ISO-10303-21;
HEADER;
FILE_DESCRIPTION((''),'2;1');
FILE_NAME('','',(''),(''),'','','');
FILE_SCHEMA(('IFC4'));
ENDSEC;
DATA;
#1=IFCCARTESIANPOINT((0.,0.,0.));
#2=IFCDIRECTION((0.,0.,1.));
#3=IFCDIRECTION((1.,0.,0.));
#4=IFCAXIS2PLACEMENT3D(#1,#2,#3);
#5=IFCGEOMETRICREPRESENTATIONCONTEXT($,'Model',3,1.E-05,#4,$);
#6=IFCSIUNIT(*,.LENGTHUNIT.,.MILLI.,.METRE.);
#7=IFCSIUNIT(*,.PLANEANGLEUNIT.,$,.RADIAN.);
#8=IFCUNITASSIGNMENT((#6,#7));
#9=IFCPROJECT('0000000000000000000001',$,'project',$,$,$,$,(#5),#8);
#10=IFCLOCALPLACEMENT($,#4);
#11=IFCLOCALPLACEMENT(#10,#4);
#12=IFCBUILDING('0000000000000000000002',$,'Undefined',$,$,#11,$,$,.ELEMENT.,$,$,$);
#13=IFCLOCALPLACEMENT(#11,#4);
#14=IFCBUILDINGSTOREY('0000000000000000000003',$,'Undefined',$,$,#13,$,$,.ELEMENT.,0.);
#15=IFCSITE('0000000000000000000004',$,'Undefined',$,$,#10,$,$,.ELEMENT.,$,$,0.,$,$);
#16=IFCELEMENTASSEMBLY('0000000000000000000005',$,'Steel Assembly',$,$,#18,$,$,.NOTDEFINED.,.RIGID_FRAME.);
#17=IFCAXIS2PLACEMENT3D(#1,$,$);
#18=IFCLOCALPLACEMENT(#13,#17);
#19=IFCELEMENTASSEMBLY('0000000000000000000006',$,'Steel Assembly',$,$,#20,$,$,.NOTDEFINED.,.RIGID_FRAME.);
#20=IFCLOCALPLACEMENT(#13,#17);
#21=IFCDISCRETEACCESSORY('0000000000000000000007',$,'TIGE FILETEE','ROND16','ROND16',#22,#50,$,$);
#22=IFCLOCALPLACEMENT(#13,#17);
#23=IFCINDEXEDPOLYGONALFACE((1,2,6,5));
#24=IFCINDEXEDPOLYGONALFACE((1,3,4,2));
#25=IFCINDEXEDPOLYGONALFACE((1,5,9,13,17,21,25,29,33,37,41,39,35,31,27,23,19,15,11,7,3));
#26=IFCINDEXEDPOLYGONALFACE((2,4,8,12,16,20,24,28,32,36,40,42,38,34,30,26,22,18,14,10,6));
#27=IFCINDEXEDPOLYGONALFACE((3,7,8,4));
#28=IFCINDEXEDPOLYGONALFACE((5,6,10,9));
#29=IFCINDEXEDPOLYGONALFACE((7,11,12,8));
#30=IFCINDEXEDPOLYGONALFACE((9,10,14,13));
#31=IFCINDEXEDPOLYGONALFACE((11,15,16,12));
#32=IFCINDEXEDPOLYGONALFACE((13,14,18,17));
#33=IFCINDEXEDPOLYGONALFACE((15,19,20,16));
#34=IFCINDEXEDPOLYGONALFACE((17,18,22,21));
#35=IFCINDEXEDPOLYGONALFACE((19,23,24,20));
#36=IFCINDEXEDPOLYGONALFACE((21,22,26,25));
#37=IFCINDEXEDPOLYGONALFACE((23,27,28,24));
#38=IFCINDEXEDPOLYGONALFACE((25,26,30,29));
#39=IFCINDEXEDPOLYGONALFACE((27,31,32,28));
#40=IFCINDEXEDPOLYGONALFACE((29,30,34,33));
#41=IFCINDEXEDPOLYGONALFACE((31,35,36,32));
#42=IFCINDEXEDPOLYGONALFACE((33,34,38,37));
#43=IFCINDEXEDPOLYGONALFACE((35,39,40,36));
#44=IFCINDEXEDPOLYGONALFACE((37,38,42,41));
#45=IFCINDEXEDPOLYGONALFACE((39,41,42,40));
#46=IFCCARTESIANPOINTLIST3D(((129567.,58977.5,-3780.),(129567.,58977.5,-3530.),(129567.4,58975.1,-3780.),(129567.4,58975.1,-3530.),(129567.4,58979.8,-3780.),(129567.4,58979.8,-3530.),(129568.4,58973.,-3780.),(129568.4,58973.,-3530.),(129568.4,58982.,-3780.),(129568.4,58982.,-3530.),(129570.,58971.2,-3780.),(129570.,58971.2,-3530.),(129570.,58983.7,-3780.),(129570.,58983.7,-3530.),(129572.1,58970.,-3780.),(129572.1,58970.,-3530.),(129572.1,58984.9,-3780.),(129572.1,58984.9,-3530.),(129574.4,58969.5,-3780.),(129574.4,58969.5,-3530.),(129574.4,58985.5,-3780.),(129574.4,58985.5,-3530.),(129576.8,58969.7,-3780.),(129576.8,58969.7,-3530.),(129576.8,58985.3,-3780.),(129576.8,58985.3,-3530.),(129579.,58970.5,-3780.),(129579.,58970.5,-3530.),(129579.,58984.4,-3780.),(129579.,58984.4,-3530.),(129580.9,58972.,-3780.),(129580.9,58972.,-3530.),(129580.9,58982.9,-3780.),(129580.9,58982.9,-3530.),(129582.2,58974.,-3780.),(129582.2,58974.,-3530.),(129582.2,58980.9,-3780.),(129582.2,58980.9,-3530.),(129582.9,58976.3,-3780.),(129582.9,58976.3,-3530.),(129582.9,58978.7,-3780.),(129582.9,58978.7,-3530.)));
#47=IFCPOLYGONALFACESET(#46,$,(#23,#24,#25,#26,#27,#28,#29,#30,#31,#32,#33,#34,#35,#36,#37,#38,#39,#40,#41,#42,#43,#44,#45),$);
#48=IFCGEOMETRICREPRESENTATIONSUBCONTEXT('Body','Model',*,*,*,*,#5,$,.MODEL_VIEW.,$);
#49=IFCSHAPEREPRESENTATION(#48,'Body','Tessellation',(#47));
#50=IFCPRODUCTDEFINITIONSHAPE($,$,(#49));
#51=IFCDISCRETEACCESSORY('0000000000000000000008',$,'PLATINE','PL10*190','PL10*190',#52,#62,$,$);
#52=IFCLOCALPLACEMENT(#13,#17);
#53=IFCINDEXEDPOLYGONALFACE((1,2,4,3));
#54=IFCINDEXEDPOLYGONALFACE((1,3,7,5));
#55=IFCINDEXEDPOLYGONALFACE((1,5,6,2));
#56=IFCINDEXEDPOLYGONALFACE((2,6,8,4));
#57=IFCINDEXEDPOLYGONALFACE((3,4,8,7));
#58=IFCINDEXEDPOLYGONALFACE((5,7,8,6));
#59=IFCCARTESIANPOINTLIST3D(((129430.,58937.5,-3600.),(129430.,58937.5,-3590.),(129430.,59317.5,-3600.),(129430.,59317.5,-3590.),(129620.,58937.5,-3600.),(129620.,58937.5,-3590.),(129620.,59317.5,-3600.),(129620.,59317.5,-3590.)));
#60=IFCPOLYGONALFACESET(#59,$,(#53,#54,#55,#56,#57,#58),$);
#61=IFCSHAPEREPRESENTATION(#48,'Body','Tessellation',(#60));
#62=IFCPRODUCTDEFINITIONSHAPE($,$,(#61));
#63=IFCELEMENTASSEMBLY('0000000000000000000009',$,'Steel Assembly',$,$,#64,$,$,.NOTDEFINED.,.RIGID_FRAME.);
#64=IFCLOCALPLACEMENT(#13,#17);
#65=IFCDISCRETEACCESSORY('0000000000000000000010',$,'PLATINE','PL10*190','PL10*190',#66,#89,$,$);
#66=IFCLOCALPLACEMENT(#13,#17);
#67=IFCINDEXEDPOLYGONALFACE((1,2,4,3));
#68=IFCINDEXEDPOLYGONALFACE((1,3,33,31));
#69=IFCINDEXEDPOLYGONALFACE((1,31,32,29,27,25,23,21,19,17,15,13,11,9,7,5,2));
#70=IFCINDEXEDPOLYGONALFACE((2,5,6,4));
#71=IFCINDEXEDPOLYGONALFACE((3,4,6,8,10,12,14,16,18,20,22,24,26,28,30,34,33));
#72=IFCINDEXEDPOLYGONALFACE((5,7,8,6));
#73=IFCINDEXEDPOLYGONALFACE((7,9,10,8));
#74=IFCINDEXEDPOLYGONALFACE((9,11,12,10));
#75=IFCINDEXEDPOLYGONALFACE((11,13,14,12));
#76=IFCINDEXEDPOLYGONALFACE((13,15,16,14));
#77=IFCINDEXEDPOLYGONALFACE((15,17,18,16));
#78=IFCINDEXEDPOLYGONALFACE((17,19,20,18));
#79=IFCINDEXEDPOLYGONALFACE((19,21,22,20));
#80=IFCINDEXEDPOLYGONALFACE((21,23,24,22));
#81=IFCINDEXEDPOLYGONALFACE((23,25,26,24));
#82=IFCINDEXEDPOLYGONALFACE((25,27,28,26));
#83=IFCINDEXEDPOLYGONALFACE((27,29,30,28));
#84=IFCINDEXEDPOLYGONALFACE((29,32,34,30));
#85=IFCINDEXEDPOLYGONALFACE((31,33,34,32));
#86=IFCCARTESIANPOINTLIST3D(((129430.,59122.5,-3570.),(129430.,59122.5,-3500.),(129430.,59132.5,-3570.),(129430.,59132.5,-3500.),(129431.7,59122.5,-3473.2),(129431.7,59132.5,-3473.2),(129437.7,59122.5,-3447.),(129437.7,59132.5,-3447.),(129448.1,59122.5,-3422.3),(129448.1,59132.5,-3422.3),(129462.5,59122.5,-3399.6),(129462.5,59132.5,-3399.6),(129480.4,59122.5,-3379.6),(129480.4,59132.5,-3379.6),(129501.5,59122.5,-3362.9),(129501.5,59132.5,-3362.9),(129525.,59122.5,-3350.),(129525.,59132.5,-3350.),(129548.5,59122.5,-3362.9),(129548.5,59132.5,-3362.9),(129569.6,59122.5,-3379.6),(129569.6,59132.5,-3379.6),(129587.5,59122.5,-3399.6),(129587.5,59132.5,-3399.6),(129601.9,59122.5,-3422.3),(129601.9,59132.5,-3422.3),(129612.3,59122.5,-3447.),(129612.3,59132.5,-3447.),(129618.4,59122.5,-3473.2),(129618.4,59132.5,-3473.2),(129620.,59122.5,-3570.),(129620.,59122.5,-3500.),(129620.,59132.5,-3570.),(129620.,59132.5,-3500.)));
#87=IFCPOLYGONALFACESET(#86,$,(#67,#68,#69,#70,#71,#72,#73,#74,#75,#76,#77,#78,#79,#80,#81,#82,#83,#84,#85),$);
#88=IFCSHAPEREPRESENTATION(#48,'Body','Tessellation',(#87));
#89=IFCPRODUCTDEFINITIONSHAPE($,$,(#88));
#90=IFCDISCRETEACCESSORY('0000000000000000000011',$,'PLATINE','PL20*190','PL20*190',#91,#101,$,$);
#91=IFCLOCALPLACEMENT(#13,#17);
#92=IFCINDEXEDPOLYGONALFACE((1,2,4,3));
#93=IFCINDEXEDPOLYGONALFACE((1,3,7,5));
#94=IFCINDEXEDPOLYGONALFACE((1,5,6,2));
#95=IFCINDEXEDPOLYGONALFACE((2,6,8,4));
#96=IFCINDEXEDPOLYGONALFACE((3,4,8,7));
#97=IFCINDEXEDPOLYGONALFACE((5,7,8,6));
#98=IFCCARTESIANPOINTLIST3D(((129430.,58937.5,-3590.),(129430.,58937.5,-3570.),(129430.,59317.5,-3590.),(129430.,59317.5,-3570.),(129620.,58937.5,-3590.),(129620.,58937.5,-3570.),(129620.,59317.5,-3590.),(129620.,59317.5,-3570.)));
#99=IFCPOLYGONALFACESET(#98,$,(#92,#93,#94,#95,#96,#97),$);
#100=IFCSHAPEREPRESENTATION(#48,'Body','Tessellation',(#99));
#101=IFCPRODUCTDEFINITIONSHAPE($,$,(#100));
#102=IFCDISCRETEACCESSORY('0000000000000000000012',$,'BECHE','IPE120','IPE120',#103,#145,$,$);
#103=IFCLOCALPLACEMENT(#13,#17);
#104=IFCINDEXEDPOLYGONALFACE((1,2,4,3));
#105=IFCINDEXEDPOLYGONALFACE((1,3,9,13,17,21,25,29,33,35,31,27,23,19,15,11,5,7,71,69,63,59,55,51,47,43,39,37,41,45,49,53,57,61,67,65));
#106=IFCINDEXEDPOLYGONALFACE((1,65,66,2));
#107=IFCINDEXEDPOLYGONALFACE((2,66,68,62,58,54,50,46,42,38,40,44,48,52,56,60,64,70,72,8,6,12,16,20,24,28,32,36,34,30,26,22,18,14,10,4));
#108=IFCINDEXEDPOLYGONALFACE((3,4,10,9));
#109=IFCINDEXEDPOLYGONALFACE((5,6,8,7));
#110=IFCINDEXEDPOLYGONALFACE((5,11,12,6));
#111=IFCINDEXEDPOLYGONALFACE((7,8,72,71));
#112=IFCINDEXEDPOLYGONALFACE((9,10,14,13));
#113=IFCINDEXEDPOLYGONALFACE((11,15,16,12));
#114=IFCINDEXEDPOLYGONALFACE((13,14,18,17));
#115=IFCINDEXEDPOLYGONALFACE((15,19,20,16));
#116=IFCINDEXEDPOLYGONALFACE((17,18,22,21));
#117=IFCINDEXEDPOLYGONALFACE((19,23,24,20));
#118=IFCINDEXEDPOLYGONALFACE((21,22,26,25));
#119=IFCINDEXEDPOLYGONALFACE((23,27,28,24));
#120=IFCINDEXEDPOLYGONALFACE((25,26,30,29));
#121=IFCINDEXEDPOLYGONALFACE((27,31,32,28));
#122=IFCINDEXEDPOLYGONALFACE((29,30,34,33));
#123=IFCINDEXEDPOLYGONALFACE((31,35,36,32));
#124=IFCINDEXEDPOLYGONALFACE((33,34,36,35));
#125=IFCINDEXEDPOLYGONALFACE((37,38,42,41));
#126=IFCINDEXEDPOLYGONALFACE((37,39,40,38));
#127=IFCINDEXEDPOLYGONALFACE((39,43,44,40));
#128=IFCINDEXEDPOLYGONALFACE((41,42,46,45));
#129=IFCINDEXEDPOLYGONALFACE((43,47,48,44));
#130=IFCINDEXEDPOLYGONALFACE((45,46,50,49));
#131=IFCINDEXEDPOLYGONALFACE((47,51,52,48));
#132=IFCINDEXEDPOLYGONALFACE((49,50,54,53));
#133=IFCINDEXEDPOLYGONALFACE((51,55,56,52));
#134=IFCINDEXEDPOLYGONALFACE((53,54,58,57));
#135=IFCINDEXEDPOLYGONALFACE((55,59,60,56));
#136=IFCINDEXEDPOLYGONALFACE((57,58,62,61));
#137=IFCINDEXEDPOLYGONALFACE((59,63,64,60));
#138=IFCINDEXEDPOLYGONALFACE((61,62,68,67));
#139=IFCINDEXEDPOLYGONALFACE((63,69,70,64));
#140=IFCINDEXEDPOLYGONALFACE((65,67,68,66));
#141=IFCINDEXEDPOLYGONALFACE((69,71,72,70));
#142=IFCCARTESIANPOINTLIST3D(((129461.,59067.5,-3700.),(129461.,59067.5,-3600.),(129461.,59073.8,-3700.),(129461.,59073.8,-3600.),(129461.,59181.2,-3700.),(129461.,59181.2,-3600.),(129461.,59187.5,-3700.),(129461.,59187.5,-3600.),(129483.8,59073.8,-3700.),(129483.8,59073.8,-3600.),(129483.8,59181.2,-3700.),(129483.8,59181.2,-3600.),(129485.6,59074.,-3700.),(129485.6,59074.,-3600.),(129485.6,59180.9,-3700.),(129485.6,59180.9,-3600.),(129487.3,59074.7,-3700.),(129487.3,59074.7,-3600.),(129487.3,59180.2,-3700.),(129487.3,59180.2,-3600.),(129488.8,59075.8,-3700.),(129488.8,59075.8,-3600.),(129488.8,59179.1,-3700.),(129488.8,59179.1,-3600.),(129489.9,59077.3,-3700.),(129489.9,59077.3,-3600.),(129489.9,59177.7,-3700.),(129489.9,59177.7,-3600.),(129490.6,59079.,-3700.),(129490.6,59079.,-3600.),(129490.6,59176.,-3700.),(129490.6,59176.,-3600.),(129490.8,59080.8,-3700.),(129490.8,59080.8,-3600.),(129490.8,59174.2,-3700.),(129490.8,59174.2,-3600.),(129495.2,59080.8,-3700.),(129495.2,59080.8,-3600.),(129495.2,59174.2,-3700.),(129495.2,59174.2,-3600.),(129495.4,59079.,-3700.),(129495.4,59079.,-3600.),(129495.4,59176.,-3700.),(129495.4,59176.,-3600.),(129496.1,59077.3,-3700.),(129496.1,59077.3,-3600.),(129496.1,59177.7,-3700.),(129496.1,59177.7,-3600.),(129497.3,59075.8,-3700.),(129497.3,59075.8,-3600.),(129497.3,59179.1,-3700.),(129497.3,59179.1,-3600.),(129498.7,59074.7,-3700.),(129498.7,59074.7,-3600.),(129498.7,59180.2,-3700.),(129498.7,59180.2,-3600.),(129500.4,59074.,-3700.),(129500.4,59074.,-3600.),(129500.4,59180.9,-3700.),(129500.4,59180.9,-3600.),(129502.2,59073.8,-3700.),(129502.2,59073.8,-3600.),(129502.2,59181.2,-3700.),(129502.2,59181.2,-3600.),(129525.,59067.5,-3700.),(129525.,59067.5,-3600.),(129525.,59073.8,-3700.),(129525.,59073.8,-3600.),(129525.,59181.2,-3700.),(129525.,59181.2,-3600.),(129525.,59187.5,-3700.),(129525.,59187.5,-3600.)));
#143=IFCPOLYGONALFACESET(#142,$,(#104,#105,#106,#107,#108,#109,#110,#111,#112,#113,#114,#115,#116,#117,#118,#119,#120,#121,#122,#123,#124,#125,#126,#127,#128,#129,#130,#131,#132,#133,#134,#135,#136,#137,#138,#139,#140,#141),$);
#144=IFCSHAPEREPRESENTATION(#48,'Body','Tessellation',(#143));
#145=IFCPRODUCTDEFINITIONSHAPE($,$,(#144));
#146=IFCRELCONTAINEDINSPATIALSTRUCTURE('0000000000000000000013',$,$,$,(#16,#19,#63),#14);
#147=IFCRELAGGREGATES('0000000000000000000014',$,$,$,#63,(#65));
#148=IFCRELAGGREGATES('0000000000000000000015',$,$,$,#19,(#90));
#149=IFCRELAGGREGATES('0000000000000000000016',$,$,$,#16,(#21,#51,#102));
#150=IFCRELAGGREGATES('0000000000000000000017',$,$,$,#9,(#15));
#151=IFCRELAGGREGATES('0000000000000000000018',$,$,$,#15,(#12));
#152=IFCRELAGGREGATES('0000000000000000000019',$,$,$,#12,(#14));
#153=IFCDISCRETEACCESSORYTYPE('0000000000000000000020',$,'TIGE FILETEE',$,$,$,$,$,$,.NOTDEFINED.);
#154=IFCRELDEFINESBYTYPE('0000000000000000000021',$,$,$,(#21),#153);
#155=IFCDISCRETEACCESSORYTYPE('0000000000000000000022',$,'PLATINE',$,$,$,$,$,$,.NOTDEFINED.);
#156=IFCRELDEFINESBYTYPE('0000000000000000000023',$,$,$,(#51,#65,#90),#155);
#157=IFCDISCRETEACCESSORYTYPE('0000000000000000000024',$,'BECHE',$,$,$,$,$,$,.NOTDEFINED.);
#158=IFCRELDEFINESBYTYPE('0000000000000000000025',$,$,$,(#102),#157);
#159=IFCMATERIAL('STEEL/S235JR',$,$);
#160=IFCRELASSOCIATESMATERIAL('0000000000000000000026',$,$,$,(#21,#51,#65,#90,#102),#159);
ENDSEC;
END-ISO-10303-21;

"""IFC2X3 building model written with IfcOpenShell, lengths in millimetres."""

from ifc_helpers import new_model, si_unit, frame, frame_2d, origin_with_axes, origin_2d_with_axis, place, context, subcontext, project, spatial, polyline, circle_curve, parameter, trimmed, segment, composite_curve, circle, i_section, outline, extrude, boolean, material, type_object, element, aggregate, save


model = new_model("IFC2X3")

# Units and contexts
model_context = context("Model", 3, precision=1e-05, world=origin_with_axes())
body_context = subcontext(model_context, "Body", "Model", "MODEL_VIEW")
ifc_project = project(units=[si_unit("LENGTHUNIT", "METRE", prefix="MILLI"), si_unit("PLANEANGLEUNIT", "RADIAN")], contexts=[model_context])

# Site, building, storey
site_placement = place(None, origin_with_axes())
site = spatial("IfcSite", under=ifc_project, at=site_placement, Name="Undefined", CompositionType="ELEMENT", RefElevation=0.0)
building_placement = place(site_placement, origin_with_axes())
building = spatial("IfcBuilding", under=site, at=building_placement, Name="Undefined", CompositionType="ELEMENT")
storey_placement = place(building_placement, origin_with_axes())
storey = spatial("IfcBuildingStorey", under=building, at=storey_placement, Name="Undefined", CompositionType="ELEMENT", Elevation=0.0)

# Shared definitions
ifc_material_1 = material(Name="STEEL/S235JR")

# Element assembly
assembly_1_placement = place(storey_placement, origin_with_axes())
assembly_1 = element("IfcElementAssembly", 1, at=assembly_1_placement, inside=storey, Name="Steel Assembly", AssemblyPlace="NOTDEFINED", PredefinedType="RIGID_FRAME")

# Element assembly
assembly_2_placement = place(storey_placement, origin_with_axes())
assembly_2 = element("IfcElementAssembly", 2, at=assembly_2_placement, inside=storey, Name="Steel Assembly", AssemblyPlace="NOTDEFINED", PredefinedType="RIGID_FRAME")

# Discrete accessories
discrete_accessory_type_1 = type_object("IfcDiscreteAccessoryType", Name="TIGE FILETEE")
discrete_accessory_1_placement = place(assembly_1_placement, frame((129575.0, 58977.5, -3530.0), z_axis=(0.0, -1.0, 0.0), x_axis=(0.0, 0.0, -1.0)))
discrete_accessory_1 = element("IfcDiscreteAccessory", 3, at=discrete_accessory_1_placement, type_object=discrete_accessory_type_1, material=ifc_material_1, Name="TIGE FILETEE", Description="ROND16", ObjectType="ROND16", context=body_context, shape_type="SweptSolid", body=[
    extrude(circle(Radius=8.0, at=origin_2d_with_axis()), frame((250.0, 0.0, 0.0), z_axis=(-1.0, 0.0, 0.0), x_axis=(0.0, -1.0, 0.0)), (0.0, 0.0, 1.0), 250.0),
])
discrete_accessory_type_2 = type_object("IfcDiscreteAccessoryType", Name="PLATINE")
discrete_accessory_2_placement = place(assembly_1_placement, frame((129525.0, 58937.5, -3595.0), z_axis=(0.0, -0.000005, -1.0), x_axis=(0.0, 1.0, -0.000005)))
discrete_accessory_2 = element("IfcDiscreteAccessory", 4, at=discrete_accessory_2_placement, type_object=discrete_accessory_type_2, material=ifc_material_1, Name="PLATINE", Description="PL10*190", ObjectType="PL10*190", context=body_context, shape_type="SweptSolid", body=[
    extrude(outline(polyline([(0.0, -95.0), (0.0, 95.0), (380.0, 95.0), (380.0, -95.0), (0.0, -95.0)])), frame((0.0, 0.0, -5.0), z_axis=(0.0, 0.0, 1.0), x_axis=(1.0, 0.0, 0.0)), (0.0, 0.0, 1.0), 10.0),
])

# Element assembly, discrete accessory
assembly_3_placement = place(storey_placement, origin_with_axes())
assembly_3 = element("IfcElementAssembly", 5, at=assembly_3_placement, inside=storey, Name="Steel Assembly", AssemblyPlace="NOTDEFINED", PredefinedType="RIGID_FRAME")
discrete_accessory_3_placement = place(assembly_3_placement, frame((129525.0, 59127.5, -3570.0), z_axis=(0.0, 1.0, 0.0), x_axis=(0.0, 0.0, 1.0)))
discrete_accessory_3 = element("IfcDiscreteAccessory", 6, at=discrete_accessory_3_placement, type_object=discrete_accessory_type_2, material=ifc_material_1, Name="PLATINE", Description="PL10*190", ObjectType="PL10*190", context=body_context, shape_type="CSG", body=[
    boolean("DIFFERENCE", boolean("DIFFERENCE", extrude(outline(polyline([(0.0, -95.0), (0.0, 95.0), (70.0, 95.0), (96.8, 93.4), (123.0, 87.3), (147.7, 76.9), (170.4, 62.5), (190.4, 44.6), (207.1, 23.5), (220.0, 0.0), (207.1, -23.5), (190.4, -44.6), (170.4, -62.5), (147.7, -76.9), (123.0, -87.3), (96.8, -93.4), (70.0, -95.0), (0.0, -95.0)])), frame((0.0, 0.0, -5.0), z_axis=(0.0, 0.0, 1.0), x_axis=(1.0, 0.0, 0.0)), (0.0, 0.0, 1.0), 10.0), extrude(outline(composite_curve([segment(trimmed(circle_curve(frame_2d((40.6, -155.0), x_axis=(-0.253614, 0.967305)), 160.2), [parameter(0.0)], [parameter(5.108742)], False, "PARAMETER"), True, "CONTINUOUS"), segment(polyline([(167.9, -57.7), (74.1, 59.4), (0.0, 0.0)]), True, "DISCONTINUOUS")], self_intersect=False)), frame((220.0, 0.0, -7.5), z_axis=(0.0, 0.0, 1.0), x_axis=(-0.625225, -0.780444, 0.0)), (0.0, 0.0, 1.0), 15.0)), extrude(outline(composite_curve([segment(trimmed(circle_curve(frame_2d((40.6, -155.0), x_axis=(-0.253614, 0.967305)), 160.2), [parameter(0.0)], [parameter(5.108742)], False, "PARAMETER"), True, "CONTINUOUS"), segment(polyline([(167.9, -57.7), (74.1, 59.4), (0.0, 0.0)]), True, "DISCONTINUOUS")], self_intersect=False)), frame((220.0, 0.0, 7.5), z_axis=(0.0, 0.0, -1.0), x_axis=(-0.625225, 0.780444, 0.0)), (0.0, 0.0, 1.0), 15.0)),
])
aggregate(assembly_3, [discrete_accessory_3])

# Discrete accessories
discrete_accessory_4_placement = place(assembly_2_placement, frame((129525.0, 58937.5, -3580.0), z_axis=(0.0, -0.000005, -1.0), x_axis=(0.0, 1.0, -0.000005)))
discrete_accessory_4 = element("IfcDiscreteAccessory", 7, at=discrete_accessory_4_placement, type_object=discrete_accessory_type_2, material=ifc_material_1, Name="PLATINE", Description="PL20*190", ObjectType="PL20*190", context=body_context, shape_type="SweptSolid", body=[
    extrude(outline(polyline([(0.0, -95.0), (0.0, 95.0), (380.0, 95.0), (380.0, -95.0), (0.0, -95.0)])), frame((0.0, 0.0, -10.0), z_axis=(0.0, 0.0, 1.0), x_axis=(1.0, 0.0, 0.0)), (0.0, 0.0, 1.0), 20.0),
])
aggregate(assembly_2, [discrete_accessory_4])
discrete_accessory_type_3 = type_object("IfcDiscreteAccessoryType", Name="BECHE")
discrete_accessory_5_placement = place(assembly_1_placement, frame((129493.0, 59127.5, -3600.0), z_axis=(0.0, -1.0, 0.0), x_axis=(0.0, 0.0, -1.0)))
discrete_accessory_5 = element("IfcDiscreteAccessory", 8, at=discrete_accessory_5_placement, type_object=discrete_accessory_type_3, material=ifc_material_1, Name="BECHE", Description="IPE120", ObjectType="IPE120", context=body_context, shape_type="SweptSolid", body=[
    extrude(i_section(OverallWidth=64.0, OverallDepth=120.0, WebThickness=4.4, FlangeThickness=6.3, FilletRadius=7.0, at=origin_2d_with_axis()), frame((100.0, 0.0, 0.0), z_axis=(-1.0, 0.0, 0.0), x_axis=(0.0, -1.0, 0.0)), (0.0, 0.0, 1.0), 100.0),
])
aggregate(assembly_1, [discrete_accessory_1, discrete_accessory_2, discrete_accessory_5])

save(model, "model.ifc")
